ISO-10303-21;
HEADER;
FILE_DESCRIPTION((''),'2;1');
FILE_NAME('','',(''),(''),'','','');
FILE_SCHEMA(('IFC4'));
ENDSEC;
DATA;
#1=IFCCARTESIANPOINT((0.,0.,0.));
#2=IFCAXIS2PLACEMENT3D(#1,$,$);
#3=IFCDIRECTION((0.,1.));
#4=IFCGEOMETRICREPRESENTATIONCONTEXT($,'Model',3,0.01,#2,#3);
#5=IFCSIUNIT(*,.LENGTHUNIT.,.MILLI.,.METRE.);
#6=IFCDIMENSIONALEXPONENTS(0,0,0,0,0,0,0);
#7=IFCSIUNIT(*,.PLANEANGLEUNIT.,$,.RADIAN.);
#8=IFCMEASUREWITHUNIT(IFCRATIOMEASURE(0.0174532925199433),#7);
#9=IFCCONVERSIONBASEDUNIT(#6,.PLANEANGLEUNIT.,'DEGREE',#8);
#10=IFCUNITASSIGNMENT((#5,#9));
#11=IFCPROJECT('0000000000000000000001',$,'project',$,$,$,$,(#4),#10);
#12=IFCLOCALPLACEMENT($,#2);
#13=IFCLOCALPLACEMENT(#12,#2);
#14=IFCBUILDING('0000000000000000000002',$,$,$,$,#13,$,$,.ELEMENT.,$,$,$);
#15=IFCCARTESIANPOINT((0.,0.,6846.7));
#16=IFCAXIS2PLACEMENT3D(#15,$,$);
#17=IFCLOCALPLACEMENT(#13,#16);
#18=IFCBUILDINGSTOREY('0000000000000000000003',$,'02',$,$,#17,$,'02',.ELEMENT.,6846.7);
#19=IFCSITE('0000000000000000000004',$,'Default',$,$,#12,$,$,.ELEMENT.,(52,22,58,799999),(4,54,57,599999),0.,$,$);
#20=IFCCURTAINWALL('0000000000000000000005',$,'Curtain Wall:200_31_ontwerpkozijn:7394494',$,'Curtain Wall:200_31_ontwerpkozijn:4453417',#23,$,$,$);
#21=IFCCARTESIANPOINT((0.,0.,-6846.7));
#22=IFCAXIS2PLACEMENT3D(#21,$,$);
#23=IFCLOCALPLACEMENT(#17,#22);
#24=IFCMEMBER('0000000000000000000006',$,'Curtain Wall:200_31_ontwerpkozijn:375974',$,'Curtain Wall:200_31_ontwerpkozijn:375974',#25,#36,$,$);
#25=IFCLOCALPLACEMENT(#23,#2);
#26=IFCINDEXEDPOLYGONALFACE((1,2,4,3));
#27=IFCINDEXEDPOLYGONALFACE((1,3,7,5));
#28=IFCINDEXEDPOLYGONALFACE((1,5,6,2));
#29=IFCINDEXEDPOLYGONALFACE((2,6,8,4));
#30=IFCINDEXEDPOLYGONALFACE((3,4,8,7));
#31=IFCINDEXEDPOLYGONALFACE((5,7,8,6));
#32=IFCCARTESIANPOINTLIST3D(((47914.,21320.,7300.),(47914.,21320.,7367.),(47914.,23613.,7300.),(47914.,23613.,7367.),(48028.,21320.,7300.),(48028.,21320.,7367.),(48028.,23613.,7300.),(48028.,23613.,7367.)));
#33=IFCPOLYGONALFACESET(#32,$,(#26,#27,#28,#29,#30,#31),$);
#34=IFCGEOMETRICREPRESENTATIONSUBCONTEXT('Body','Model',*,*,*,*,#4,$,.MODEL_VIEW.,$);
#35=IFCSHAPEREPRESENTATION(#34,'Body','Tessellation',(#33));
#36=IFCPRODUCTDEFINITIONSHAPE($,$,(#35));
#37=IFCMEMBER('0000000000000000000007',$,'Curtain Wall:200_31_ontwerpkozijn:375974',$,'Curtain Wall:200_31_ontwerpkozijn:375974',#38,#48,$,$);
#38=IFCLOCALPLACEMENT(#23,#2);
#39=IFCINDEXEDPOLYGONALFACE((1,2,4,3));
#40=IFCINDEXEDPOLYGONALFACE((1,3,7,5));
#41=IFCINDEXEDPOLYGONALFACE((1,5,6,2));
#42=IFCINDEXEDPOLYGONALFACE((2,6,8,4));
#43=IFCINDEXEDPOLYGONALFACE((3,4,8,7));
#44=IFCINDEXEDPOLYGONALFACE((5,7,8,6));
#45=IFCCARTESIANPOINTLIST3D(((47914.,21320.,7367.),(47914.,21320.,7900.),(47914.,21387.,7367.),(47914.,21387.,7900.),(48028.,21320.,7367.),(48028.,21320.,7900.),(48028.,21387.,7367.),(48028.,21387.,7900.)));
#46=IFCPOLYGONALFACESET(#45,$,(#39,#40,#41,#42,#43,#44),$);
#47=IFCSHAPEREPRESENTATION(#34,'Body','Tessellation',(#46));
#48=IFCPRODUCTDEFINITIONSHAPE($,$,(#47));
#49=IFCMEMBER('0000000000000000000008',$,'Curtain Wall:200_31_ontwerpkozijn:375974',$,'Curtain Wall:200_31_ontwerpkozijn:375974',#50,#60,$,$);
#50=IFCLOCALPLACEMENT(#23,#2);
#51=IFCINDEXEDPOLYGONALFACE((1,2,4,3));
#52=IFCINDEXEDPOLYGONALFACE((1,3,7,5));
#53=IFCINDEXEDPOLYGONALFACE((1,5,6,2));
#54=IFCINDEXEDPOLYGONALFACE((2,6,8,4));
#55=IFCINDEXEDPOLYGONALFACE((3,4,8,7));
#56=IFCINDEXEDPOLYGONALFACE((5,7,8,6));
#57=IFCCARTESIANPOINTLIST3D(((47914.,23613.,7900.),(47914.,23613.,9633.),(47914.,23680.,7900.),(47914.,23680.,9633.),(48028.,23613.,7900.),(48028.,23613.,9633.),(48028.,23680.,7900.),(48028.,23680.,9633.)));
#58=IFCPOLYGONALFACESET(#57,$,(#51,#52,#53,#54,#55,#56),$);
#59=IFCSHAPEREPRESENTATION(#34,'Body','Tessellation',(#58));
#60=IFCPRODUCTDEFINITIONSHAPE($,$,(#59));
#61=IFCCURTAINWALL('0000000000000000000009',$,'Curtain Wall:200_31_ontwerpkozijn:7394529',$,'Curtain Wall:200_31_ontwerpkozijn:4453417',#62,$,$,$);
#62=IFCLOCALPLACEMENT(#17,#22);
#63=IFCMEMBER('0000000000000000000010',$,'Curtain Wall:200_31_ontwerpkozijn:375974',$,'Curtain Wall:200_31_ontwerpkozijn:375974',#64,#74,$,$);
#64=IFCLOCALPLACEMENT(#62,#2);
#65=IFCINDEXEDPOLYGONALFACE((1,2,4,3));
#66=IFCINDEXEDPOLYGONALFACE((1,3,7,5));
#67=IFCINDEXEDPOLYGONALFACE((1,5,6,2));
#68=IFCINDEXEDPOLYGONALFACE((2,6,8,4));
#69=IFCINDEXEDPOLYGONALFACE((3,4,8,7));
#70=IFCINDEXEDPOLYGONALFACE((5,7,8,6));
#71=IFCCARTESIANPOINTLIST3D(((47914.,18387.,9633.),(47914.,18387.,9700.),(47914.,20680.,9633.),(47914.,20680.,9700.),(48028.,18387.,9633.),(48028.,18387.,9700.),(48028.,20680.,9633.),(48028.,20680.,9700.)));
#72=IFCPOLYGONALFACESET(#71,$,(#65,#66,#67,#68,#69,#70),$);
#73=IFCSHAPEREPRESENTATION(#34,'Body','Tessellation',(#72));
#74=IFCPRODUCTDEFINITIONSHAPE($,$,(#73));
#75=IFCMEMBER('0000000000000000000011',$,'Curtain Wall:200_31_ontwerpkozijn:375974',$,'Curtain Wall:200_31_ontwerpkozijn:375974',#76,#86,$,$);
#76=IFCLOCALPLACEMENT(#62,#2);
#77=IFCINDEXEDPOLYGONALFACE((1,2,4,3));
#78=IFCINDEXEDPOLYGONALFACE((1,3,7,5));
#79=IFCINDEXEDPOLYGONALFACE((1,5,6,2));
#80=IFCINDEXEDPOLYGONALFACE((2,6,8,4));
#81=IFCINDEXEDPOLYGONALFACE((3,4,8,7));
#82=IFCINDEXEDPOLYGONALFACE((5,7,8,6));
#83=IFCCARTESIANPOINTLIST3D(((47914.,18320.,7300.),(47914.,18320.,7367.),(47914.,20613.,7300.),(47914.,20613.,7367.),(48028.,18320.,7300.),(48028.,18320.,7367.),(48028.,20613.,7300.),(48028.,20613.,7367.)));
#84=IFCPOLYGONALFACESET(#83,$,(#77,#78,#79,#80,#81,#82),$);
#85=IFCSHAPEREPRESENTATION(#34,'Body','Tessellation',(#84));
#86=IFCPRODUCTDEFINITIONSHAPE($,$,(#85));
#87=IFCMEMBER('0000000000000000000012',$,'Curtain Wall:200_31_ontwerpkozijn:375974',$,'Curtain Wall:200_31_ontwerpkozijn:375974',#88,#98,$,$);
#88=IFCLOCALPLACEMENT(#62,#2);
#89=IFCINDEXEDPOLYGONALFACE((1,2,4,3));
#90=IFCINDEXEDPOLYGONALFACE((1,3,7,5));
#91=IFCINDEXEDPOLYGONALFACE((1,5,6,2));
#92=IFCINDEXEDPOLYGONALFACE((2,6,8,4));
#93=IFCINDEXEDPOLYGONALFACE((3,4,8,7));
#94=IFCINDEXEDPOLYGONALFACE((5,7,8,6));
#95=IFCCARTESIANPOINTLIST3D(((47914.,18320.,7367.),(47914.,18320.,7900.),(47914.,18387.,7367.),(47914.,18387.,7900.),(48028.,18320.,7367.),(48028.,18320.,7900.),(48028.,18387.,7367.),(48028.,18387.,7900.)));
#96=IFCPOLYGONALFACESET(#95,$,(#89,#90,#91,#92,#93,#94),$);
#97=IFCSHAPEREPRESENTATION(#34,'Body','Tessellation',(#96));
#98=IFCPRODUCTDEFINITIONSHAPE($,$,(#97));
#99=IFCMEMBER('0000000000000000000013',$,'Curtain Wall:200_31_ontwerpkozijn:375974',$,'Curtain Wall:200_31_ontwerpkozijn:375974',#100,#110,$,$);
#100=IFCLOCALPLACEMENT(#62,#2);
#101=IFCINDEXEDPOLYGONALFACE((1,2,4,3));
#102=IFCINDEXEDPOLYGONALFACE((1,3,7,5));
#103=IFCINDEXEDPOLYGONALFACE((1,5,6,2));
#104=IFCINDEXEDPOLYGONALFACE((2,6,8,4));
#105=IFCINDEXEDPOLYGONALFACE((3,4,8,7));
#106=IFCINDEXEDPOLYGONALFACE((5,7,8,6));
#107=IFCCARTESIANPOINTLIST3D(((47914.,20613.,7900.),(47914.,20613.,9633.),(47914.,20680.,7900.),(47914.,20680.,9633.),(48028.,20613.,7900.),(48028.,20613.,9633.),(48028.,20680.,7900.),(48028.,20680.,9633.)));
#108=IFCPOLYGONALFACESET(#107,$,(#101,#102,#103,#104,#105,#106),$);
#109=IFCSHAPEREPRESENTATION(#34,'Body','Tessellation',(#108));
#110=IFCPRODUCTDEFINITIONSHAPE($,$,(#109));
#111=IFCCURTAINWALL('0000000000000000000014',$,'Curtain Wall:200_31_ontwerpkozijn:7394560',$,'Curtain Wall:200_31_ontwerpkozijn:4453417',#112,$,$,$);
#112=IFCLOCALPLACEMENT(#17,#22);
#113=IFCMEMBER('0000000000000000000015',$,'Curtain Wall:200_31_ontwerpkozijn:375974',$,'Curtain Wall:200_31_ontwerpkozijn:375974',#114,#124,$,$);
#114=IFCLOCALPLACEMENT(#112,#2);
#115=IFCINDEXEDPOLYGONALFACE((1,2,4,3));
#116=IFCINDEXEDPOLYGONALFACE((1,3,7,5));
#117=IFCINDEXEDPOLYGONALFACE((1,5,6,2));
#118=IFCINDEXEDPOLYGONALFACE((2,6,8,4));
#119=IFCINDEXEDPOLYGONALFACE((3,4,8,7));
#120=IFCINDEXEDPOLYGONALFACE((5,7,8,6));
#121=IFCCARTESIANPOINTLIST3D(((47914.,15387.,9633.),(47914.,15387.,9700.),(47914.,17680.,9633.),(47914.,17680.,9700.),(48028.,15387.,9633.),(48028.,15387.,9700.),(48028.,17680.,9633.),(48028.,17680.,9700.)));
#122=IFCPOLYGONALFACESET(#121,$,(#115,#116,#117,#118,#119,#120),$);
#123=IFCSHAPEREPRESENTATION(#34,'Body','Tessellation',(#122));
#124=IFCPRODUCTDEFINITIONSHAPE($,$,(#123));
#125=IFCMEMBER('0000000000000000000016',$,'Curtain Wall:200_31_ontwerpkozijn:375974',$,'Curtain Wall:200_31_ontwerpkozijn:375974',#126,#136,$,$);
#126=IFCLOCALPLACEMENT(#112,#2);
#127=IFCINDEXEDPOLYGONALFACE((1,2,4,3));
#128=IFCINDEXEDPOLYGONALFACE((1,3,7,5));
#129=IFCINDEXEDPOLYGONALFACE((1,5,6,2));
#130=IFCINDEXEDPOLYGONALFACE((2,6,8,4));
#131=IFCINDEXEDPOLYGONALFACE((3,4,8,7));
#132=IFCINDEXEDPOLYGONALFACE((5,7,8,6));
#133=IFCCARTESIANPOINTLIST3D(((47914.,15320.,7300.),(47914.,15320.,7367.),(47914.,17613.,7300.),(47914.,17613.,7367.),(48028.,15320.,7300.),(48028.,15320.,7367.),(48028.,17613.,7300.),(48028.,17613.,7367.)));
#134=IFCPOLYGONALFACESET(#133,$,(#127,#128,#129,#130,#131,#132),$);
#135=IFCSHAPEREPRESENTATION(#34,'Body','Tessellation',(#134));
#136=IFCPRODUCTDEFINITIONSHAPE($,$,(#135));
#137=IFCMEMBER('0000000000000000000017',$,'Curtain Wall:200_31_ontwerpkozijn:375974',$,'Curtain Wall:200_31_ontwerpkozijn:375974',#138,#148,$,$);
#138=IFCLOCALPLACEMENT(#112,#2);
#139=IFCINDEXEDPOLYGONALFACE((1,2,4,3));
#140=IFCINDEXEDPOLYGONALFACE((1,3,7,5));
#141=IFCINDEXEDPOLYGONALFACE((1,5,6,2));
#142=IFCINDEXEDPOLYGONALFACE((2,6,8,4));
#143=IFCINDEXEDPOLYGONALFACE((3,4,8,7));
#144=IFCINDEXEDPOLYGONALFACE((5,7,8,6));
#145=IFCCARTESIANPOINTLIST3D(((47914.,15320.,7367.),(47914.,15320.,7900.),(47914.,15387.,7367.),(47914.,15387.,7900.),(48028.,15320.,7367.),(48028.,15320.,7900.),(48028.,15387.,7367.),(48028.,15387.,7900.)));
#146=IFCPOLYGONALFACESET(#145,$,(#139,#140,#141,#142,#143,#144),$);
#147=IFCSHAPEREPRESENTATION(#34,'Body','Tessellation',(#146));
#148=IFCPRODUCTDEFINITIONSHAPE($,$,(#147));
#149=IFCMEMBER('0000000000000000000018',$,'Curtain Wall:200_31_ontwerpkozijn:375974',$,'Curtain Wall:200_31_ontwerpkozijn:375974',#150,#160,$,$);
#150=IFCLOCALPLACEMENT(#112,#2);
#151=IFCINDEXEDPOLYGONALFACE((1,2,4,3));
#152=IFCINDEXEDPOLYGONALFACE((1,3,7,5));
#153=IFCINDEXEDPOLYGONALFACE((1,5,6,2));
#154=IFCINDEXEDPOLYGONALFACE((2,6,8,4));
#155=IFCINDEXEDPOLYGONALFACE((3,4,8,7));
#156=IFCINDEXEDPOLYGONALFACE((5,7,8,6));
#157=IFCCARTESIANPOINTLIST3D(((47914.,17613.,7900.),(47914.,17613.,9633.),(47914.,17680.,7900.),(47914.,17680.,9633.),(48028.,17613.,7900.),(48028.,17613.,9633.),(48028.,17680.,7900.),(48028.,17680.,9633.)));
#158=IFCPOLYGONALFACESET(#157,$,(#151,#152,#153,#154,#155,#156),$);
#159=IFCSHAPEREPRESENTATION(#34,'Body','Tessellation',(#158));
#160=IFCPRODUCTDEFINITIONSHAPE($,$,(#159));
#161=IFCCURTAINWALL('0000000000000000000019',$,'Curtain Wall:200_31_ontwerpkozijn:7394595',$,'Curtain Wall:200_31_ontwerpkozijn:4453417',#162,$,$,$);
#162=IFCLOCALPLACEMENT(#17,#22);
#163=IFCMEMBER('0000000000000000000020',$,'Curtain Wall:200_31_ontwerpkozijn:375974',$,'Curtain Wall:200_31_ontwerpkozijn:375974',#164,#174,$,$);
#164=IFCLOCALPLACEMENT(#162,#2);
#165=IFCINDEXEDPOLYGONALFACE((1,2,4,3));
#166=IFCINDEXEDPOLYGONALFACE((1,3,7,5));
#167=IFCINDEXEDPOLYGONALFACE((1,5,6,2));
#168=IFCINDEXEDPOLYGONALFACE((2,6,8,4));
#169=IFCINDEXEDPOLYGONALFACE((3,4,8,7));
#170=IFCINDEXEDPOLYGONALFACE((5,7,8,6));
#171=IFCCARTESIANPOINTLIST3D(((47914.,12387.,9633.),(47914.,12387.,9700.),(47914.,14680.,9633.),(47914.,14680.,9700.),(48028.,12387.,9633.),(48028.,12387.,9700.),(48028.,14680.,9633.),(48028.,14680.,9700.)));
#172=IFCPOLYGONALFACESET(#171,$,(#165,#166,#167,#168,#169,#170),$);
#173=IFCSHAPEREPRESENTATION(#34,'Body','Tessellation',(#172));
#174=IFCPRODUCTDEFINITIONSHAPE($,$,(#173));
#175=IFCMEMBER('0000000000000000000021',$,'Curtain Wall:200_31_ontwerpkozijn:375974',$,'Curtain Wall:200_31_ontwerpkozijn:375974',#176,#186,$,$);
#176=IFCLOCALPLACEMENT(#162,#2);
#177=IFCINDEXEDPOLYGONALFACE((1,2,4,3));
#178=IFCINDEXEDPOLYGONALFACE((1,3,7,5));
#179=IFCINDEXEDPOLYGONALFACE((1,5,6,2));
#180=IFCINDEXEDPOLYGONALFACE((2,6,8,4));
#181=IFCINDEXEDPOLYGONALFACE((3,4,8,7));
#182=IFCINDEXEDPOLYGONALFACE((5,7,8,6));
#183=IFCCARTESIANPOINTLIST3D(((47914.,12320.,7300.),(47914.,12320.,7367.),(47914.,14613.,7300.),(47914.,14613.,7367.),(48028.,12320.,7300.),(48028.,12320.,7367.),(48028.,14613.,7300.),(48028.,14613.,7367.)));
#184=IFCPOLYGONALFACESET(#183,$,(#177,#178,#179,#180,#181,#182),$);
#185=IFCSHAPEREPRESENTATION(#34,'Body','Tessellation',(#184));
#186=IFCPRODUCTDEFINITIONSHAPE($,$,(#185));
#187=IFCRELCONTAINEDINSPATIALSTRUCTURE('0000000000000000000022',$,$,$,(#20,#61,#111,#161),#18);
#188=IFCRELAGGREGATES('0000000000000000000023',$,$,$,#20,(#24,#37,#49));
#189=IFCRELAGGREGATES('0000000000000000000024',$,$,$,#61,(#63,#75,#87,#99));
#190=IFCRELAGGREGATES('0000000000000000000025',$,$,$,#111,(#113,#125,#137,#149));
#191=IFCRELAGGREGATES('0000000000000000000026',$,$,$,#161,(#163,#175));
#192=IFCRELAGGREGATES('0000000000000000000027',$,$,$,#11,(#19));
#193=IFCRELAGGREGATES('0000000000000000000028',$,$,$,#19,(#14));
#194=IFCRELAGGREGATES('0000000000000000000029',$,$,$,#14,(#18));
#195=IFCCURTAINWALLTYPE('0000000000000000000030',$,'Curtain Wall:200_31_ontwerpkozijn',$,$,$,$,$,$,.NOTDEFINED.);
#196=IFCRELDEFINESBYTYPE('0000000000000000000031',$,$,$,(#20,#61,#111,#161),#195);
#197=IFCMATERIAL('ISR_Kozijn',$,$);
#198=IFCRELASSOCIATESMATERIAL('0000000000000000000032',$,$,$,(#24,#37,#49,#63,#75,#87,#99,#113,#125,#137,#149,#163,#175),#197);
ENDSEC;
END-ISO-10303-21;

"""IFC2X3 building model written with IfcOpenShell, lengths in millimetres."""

from ifc_helpers import new_model, entity, si_unit, converted_unit, direction, frame, frame_2d, origin, place, context, subcontext, project, spatial, rectangle, extrude, material, type_object, element, aggregate, save


model = new_model("IFC2X3")

# Units and contexts
model_context = context("Model", 3, precision=0.01, world=origin(), true_north=direction((0.0, 1.0)))
body_context = subcontext(model_context, "Body", "Model", "MODEL_VIEW")
ifc_project = project(units=[si_unit("LENGTHUNIT", "METRE", prefix="MILLI"), converted_unit("PLANEANGLEUNIT", "DEGREE", entity("IfcRatioMeasure", 0.0174532925199433), si_unit("PLANEANGLEUNIT", "RADIAN"), dimensions=[0, 0, 0, 0, 0, 0, 0])], contexts=[model_context])

# Site, building, storey
site_placement = place(None, origin())
site = spatial("IfcSite", under=ifc_project, at=site_placement, Name="Default", CompositionType="ELEMENT", RefLatitude=(52, 22, 58, 799999), RefLongitude=(4, 54, 57, 599999), RefElevation=0.0)
building_placement = place(site_placement, origin())
building = spatial("IfcBuilding", under=site, at=building_placement, CompositionType="ELEMENT")
storey_placement = place(building_placement, frame((0.0, 0.0, 6846.7)))
storey = spatial("IfcBuildingStorey", under=building, at=storey_placement, Name="02", LongName="02", CompositionType="ELEMENT", Elevation=6846.7)

# Curtain walls, members
curtain_wall_type = type_object("IfcCurtainWallType", Name="Curtain Wall:200_31_ontwerpkozijn", PredefinedType="NOTDEFINED")
ifc_material = material(Name="ISR_Kozijn")
curtain_wall_1_placement = place(storey_placement, frame((0.0, 0.0, -6846.7)))
curtain_wall_1 = element("IfcCurtainWall", 1, at=curtain_wall_1_placement, inside=storey, type_object=curtain_wall_type, Name="Curtain Wall:200_31_ontwerpkozijn:7394494", ObjectType="Curtain Wall:200_31_ontwerpkozijn:4453417")
member_1_placement = place(curtain_wall_1_placement, origin())
member_1 = element("IfcMember", 2, at=member_1_placement, material=ifc_material, Name="Curtain Wall:200_31_ontwerpkozijn:375974", ObjectType="Curtain Wall:200_31_ontwerpkozijn:375974", context=body_context, shape_type="SweptSolid", body=[
    extrude(rectangle(XDim=67.0, YDim=114.0, at=frame_2d((0.0, 0.0), x_axis=(1.0, 0.0))), frame((47971.0, 23613.0, 7333.5), z_axis=(0.0, -1.0, 0.0), x_axis=(0.0, 0.0, -1.0)), (0.0, 0.0, 1.0), 2293.0),
])
member_2_placement = place(curtain_wall_1_placement, origin())
member_2 = element("IfcMember", 3, at=member_2_placement, material=ifc_material, Name="Curtain Wall:200_31_ontwerpkozijn:375974", ObjectType="Curtain Wall:200_31_ontwerpkozijn:375974", context=body_context, shape_type="SweptSolid", body=[
    extrude(rectangle(XDim=114.0, YDim=67.0, at=frame_2d((0.0, 0.0), x_axis=(1.0, 0.0))), frame((47971.0, 21353.5, 7367.0), z_axis=(0.0, 0.0, 1.0), x_axis=(-1.0, 0.0, 0.0)), (0.0, 0.0, 1.0), 533.0),
])
member_3_placement = place(curtain_wall_1_placement, origin())
member_3 = element("IfcMember", 4, at=member_3_placement, material=ifc_material, Name="Curtain Wall:200_31_ontwerpkozijn:375974", ObjectType="Curtain Wall:200_31_ontwerpkozijn:375974", context=body_context, shape_type="SweptSolid", body=[
    extrude(rectangle(XDim=114.0, YDim=67.0, at=frame_2d((0.0, 0.0), x_axis=(1.0, 0.0))), frame((47971.0, 23646.5, 9633.0), z_axis=(0.0, 0.0, -1.0), x_axis=(-1.0, 0.0, 0.0)), (0.0, 0.0, 1.0), 1733.0),
])
aggregate(curtain_wall_1, [member_1, member_2, member_3])
curtain_wall_2_placement = place(storey_placement, frame((0.0, 0.0, -6846.7)))
curtain_wall_2 = element("IfcCurtainWall", 5, at=curtain_wall_2_placement, inside=storey, type_object=curtain_wall_type, Name="Curtain Wall:200_31_ontwerpkozijn:7394529", ObjectType="Curtain Wall:200_31_ontwerpkozijn:4453417")
member_4_placement = place(curtain_wall_2_placement, origin())
member_4 = element("IfcMember", 6, at=member_4_placement, material=ifc_material, Name="Curtain Wall:200_31_ontwerpkozijn:375974", ObjectType="Curtain Wall:200_31_ontwerpkozijn:375974", context=body_context, shape_type="SweptSolid", body=[
    extrude(rectangle(XDim=67.0, YDim=114.0, at=frame_2d((0.0, 0.0), x_axis=(1.0, 0.0))), frame((47971.0, 18387.0, 9666.5), z_axis=(0.0, 1.0, 0.0), x_axis=(0.0, 0.0, -1.0)), (0.0, 0.0, 1.0), 2293.0),
])
member_5_placement = place(curtain_wall_2_placement, origin())
member_5 = element("IfcMember", 7, at=member_5_placement, material=ifc_material, Name="Curtain Wall:200_31_ontwerpkozijn:375974", ObjectType="Curtain Wall:200_31_ontwerpkozijn:375974", context=body_context, shape_type="SweptSolid", body=[
    extrude(rectangle(XDim=67.0, YDim=114.0, at=frame_2d((0.0, 0.0), x_axis=(1.0, 0.0))), frame((47971.0, 20613.0, 7333.5), z_axis=(0.0, -1.0, 0.0), x_axis=(0.0, 0.0, -1.0)), (0.0, 0.0, 1.0), 2293.0),
])
member_6_placement = place(curtain_wall_2_placement, origin())
member_6 = element("IfcMember", 8, at=member_6_placement, material=ifc_material, Name="Curtain Wall:200_31_ontwerpkozijn:375974", ObjectType="Curtain Wall:200_31_ontwerpkozijn:375974", context=body_context, shape_type="SweptSolid", body=[
    extrude(rectangle(XDim=114.0, YDim=67.0, at=frame_2d((0.0, 0.0), x_axis=(1.0, 0.0))), frame((47971.0, 18353.5, 7367.0), z_axis=(0.0, 0.0, 1.0), x_axis=(-1.0, 0.0, 0.0)), (0.0, 0.0, 1.0), 533.0),
])
member_7_placement = place(curtain_wall_2_placement, origin())
member_7 = element("IfcMember", 9, at=member_7_placement, material=ifc_material, Name="Curtain Wall:200_31_ontwerpkozijn:375974", ObjectType="Curtain Wall:200_31_ontwerpkozijn:375974", context=body_context, shape_type="SweptSolid", body=[
    extrude(rectangle(XDim=114.0, YDim=67.0, at=frame_2d((0.0, 0.0), x_axis=(1.0, 0.0))), frame((47971.0, 20646.5, 9633.0), z_axis=(0.0, 0.0, -1.0), x_axis=(-1.0, 0.0, 0.0)), (0.0, 0.0, 1.0), 1733.0),
])
aggregate(curtain_wall_2, [member_4, member_5, member_6, member_7])
curtain_wall_3_placement = place(storey_placement, frame((0.0, 0.0, -6846.7)))
curtain_wall_3 = element("IfcCurtainWall", 10, at=curtain_wall_3_placement, inside=storey, type_object=curtain_wall_type, Name="Curtain Wall:200_31_ontwerpkozijn:7394560", ObjectType="Curtain Wall:200_31_ontwerpkozijn:4453417")
member_8_placement = place(curtain_wall_3_placement, origin())
member_8 = element("IfcMember", 11, at=member_8_placement, material=ifc_material, Name="Curtain Wall:200_31_ontwerpkozijn:375974", ObjectType="Curtain Wall:200_31_ontwerpkozijn:375974", context=body_context, shape_type="SweptSolid", body=[
    extrude(rectangle(XDim=67.0, YDim=114.0, at=frame_2d((0.0, 0.0), x_axis=(1.0, 0.0))), frame((47971.0, 15387.0, 9666.5), z_axis=(0.0, 1.0, 0.0), x_axis=(0.0, 0.0, -1.0)), (0.0, 0.0, 1.0), 2293.0),
])
member_9_placement = place(curtain_wall_3_placement, origin())
member_9 = element("IfcMember", 12, at=member_9_placement, material=ifc_material, Name="Curtain Wall:200_31_ontwerpkozijn:375974", ObjectType="Curtain Wall:200_31_ontwerpkozijn:375974", context=body_context, shape_type="SweptSolid", body=[
    extrude(rectangle(XDim=67.0, YDim=114.0, at=frame_2d((0.0, 0.0), x_axis=(1.0, 0.0))), frame((47971.0, 17613.0, 7333.5), z_axis=(0.0, -1.0, 0.0), x_axis=(0.0, 0.0, -1.0)), (0.0, 0.0, 1.0), 2293.0),
])
member_10_placement = place(curtain_wall_3_placement, origin())
member_10 = element("IfcMember", 13, at=member_10_placement, material=ifc_material, Name="Curtain Wall:200_31_ontwerpkozijn:375974", ObjectType="Curtain Wall:200_31_ontwerpkozijn:375974", context=body_context, shape_type="SweptSolid", body=[
    extrude(rectangle(XDim=114.0, YDim=67.0, at=frame_2d((0.0, 0.0), x_axis=(1.0, 0.0))), frame((47971.0, 15353.5, 7367.0), z_axis=(0.0, 0.0, 1.0), x_axis=(-1.0, 0.0, 0.0)), (0.0, 0.0, 1.0), 533.0),
])
member_11_placement = place(curtain_wall_3_placement, origin())
member_11 = element("IfcMember", 14, at=member_11_placement, material=ifc_material, Name="Curtain Wall:200_31_ontwerpkozijn:375974", ObjectType="Curtain Wall:200_31_ontwerpkozijn:375974", context=body_context, shape_type="SweptSolid", body=[
    extrude(rectangle(XDim=114.0, YDim=67.0, at=frame_2d((0.0, 0.0), x_axis=(1.0, 0.0))), frame((47971.0, 17646.5, 9633.0), z_axis=(0.0, 0.0, -1.0), x_axis=(-1.0, 0.0, 0.0)), (0.0, 0.0, 1.0), 1733.0),
])
aggregate(curtain_wall_3, [member_8, member_9, member_10, member_11])
curtain_wall_4_placement = place(storey_placement, frame((0.0, 0.0, -6846.7)))
curtain_wall_4 = element("IfcCurtainWall", 15, at=curtain_wall_4_placement, inside=storey, type_object=curtain_wall_type, Name="Curtain Wall:200_31_ontwerpkozijn:7394595", ObjectType="Curtain Wall:200_31_ontwerpkozijn:4453417")
member_12_placement = place(curtain_wall_4_placement, origin())
member_12 = element("IfcMember", 16, at=member_12_placement, material=ifc_material, Name="Curtain Wall:200_31_ontwerpkozijn:375974", ObjectType="Curtain Wall:200_31_ontwerpkozijn:375974", context=body_context, shape_type="SweptSolid", body=[
    extrude(rectangle(XDim=67.0, YDim=114.0, at=frame_2d((0.0, 0.0), x_axis=(1.0, 0.0))), frame((47971.0, 12387.0, 9666.5), z_axis=(0.0, 1.0, 0.0), x_axis=(0.0, 0.0, -1.0)), (0.0, 0.0, 1.0), 2293.0),
])
member_13_placement = place(curtain_wall_4_placement, origin())
member_13 = element("IfcMember", 17, at=member_13_placement, material=ifc_material, Name="Curtain Wall:200_31_ontwerpkozijn:375974", ObjectType="Curtain Wall:200_31_ontwerpkozijn:375974", context=body_context, shape_type="SweptSolid", body=[
    extrude(rectangle(XDim=67.0, YDim=114.0, at=frame_2d((0.0, 0.0), x_axis=(1.0, 0.0))), frame((47971.0, 14613.0, 7333.5), z_axis=(0.0, -1.0, 0.0), x_axis=(0.0, 0.0, -1.0)), (0.0, 0.0, 1.0), 2293.0),
])
aggregate(curtain_wall_4, [member_12, member_13])

save(model, "model.ifc")
